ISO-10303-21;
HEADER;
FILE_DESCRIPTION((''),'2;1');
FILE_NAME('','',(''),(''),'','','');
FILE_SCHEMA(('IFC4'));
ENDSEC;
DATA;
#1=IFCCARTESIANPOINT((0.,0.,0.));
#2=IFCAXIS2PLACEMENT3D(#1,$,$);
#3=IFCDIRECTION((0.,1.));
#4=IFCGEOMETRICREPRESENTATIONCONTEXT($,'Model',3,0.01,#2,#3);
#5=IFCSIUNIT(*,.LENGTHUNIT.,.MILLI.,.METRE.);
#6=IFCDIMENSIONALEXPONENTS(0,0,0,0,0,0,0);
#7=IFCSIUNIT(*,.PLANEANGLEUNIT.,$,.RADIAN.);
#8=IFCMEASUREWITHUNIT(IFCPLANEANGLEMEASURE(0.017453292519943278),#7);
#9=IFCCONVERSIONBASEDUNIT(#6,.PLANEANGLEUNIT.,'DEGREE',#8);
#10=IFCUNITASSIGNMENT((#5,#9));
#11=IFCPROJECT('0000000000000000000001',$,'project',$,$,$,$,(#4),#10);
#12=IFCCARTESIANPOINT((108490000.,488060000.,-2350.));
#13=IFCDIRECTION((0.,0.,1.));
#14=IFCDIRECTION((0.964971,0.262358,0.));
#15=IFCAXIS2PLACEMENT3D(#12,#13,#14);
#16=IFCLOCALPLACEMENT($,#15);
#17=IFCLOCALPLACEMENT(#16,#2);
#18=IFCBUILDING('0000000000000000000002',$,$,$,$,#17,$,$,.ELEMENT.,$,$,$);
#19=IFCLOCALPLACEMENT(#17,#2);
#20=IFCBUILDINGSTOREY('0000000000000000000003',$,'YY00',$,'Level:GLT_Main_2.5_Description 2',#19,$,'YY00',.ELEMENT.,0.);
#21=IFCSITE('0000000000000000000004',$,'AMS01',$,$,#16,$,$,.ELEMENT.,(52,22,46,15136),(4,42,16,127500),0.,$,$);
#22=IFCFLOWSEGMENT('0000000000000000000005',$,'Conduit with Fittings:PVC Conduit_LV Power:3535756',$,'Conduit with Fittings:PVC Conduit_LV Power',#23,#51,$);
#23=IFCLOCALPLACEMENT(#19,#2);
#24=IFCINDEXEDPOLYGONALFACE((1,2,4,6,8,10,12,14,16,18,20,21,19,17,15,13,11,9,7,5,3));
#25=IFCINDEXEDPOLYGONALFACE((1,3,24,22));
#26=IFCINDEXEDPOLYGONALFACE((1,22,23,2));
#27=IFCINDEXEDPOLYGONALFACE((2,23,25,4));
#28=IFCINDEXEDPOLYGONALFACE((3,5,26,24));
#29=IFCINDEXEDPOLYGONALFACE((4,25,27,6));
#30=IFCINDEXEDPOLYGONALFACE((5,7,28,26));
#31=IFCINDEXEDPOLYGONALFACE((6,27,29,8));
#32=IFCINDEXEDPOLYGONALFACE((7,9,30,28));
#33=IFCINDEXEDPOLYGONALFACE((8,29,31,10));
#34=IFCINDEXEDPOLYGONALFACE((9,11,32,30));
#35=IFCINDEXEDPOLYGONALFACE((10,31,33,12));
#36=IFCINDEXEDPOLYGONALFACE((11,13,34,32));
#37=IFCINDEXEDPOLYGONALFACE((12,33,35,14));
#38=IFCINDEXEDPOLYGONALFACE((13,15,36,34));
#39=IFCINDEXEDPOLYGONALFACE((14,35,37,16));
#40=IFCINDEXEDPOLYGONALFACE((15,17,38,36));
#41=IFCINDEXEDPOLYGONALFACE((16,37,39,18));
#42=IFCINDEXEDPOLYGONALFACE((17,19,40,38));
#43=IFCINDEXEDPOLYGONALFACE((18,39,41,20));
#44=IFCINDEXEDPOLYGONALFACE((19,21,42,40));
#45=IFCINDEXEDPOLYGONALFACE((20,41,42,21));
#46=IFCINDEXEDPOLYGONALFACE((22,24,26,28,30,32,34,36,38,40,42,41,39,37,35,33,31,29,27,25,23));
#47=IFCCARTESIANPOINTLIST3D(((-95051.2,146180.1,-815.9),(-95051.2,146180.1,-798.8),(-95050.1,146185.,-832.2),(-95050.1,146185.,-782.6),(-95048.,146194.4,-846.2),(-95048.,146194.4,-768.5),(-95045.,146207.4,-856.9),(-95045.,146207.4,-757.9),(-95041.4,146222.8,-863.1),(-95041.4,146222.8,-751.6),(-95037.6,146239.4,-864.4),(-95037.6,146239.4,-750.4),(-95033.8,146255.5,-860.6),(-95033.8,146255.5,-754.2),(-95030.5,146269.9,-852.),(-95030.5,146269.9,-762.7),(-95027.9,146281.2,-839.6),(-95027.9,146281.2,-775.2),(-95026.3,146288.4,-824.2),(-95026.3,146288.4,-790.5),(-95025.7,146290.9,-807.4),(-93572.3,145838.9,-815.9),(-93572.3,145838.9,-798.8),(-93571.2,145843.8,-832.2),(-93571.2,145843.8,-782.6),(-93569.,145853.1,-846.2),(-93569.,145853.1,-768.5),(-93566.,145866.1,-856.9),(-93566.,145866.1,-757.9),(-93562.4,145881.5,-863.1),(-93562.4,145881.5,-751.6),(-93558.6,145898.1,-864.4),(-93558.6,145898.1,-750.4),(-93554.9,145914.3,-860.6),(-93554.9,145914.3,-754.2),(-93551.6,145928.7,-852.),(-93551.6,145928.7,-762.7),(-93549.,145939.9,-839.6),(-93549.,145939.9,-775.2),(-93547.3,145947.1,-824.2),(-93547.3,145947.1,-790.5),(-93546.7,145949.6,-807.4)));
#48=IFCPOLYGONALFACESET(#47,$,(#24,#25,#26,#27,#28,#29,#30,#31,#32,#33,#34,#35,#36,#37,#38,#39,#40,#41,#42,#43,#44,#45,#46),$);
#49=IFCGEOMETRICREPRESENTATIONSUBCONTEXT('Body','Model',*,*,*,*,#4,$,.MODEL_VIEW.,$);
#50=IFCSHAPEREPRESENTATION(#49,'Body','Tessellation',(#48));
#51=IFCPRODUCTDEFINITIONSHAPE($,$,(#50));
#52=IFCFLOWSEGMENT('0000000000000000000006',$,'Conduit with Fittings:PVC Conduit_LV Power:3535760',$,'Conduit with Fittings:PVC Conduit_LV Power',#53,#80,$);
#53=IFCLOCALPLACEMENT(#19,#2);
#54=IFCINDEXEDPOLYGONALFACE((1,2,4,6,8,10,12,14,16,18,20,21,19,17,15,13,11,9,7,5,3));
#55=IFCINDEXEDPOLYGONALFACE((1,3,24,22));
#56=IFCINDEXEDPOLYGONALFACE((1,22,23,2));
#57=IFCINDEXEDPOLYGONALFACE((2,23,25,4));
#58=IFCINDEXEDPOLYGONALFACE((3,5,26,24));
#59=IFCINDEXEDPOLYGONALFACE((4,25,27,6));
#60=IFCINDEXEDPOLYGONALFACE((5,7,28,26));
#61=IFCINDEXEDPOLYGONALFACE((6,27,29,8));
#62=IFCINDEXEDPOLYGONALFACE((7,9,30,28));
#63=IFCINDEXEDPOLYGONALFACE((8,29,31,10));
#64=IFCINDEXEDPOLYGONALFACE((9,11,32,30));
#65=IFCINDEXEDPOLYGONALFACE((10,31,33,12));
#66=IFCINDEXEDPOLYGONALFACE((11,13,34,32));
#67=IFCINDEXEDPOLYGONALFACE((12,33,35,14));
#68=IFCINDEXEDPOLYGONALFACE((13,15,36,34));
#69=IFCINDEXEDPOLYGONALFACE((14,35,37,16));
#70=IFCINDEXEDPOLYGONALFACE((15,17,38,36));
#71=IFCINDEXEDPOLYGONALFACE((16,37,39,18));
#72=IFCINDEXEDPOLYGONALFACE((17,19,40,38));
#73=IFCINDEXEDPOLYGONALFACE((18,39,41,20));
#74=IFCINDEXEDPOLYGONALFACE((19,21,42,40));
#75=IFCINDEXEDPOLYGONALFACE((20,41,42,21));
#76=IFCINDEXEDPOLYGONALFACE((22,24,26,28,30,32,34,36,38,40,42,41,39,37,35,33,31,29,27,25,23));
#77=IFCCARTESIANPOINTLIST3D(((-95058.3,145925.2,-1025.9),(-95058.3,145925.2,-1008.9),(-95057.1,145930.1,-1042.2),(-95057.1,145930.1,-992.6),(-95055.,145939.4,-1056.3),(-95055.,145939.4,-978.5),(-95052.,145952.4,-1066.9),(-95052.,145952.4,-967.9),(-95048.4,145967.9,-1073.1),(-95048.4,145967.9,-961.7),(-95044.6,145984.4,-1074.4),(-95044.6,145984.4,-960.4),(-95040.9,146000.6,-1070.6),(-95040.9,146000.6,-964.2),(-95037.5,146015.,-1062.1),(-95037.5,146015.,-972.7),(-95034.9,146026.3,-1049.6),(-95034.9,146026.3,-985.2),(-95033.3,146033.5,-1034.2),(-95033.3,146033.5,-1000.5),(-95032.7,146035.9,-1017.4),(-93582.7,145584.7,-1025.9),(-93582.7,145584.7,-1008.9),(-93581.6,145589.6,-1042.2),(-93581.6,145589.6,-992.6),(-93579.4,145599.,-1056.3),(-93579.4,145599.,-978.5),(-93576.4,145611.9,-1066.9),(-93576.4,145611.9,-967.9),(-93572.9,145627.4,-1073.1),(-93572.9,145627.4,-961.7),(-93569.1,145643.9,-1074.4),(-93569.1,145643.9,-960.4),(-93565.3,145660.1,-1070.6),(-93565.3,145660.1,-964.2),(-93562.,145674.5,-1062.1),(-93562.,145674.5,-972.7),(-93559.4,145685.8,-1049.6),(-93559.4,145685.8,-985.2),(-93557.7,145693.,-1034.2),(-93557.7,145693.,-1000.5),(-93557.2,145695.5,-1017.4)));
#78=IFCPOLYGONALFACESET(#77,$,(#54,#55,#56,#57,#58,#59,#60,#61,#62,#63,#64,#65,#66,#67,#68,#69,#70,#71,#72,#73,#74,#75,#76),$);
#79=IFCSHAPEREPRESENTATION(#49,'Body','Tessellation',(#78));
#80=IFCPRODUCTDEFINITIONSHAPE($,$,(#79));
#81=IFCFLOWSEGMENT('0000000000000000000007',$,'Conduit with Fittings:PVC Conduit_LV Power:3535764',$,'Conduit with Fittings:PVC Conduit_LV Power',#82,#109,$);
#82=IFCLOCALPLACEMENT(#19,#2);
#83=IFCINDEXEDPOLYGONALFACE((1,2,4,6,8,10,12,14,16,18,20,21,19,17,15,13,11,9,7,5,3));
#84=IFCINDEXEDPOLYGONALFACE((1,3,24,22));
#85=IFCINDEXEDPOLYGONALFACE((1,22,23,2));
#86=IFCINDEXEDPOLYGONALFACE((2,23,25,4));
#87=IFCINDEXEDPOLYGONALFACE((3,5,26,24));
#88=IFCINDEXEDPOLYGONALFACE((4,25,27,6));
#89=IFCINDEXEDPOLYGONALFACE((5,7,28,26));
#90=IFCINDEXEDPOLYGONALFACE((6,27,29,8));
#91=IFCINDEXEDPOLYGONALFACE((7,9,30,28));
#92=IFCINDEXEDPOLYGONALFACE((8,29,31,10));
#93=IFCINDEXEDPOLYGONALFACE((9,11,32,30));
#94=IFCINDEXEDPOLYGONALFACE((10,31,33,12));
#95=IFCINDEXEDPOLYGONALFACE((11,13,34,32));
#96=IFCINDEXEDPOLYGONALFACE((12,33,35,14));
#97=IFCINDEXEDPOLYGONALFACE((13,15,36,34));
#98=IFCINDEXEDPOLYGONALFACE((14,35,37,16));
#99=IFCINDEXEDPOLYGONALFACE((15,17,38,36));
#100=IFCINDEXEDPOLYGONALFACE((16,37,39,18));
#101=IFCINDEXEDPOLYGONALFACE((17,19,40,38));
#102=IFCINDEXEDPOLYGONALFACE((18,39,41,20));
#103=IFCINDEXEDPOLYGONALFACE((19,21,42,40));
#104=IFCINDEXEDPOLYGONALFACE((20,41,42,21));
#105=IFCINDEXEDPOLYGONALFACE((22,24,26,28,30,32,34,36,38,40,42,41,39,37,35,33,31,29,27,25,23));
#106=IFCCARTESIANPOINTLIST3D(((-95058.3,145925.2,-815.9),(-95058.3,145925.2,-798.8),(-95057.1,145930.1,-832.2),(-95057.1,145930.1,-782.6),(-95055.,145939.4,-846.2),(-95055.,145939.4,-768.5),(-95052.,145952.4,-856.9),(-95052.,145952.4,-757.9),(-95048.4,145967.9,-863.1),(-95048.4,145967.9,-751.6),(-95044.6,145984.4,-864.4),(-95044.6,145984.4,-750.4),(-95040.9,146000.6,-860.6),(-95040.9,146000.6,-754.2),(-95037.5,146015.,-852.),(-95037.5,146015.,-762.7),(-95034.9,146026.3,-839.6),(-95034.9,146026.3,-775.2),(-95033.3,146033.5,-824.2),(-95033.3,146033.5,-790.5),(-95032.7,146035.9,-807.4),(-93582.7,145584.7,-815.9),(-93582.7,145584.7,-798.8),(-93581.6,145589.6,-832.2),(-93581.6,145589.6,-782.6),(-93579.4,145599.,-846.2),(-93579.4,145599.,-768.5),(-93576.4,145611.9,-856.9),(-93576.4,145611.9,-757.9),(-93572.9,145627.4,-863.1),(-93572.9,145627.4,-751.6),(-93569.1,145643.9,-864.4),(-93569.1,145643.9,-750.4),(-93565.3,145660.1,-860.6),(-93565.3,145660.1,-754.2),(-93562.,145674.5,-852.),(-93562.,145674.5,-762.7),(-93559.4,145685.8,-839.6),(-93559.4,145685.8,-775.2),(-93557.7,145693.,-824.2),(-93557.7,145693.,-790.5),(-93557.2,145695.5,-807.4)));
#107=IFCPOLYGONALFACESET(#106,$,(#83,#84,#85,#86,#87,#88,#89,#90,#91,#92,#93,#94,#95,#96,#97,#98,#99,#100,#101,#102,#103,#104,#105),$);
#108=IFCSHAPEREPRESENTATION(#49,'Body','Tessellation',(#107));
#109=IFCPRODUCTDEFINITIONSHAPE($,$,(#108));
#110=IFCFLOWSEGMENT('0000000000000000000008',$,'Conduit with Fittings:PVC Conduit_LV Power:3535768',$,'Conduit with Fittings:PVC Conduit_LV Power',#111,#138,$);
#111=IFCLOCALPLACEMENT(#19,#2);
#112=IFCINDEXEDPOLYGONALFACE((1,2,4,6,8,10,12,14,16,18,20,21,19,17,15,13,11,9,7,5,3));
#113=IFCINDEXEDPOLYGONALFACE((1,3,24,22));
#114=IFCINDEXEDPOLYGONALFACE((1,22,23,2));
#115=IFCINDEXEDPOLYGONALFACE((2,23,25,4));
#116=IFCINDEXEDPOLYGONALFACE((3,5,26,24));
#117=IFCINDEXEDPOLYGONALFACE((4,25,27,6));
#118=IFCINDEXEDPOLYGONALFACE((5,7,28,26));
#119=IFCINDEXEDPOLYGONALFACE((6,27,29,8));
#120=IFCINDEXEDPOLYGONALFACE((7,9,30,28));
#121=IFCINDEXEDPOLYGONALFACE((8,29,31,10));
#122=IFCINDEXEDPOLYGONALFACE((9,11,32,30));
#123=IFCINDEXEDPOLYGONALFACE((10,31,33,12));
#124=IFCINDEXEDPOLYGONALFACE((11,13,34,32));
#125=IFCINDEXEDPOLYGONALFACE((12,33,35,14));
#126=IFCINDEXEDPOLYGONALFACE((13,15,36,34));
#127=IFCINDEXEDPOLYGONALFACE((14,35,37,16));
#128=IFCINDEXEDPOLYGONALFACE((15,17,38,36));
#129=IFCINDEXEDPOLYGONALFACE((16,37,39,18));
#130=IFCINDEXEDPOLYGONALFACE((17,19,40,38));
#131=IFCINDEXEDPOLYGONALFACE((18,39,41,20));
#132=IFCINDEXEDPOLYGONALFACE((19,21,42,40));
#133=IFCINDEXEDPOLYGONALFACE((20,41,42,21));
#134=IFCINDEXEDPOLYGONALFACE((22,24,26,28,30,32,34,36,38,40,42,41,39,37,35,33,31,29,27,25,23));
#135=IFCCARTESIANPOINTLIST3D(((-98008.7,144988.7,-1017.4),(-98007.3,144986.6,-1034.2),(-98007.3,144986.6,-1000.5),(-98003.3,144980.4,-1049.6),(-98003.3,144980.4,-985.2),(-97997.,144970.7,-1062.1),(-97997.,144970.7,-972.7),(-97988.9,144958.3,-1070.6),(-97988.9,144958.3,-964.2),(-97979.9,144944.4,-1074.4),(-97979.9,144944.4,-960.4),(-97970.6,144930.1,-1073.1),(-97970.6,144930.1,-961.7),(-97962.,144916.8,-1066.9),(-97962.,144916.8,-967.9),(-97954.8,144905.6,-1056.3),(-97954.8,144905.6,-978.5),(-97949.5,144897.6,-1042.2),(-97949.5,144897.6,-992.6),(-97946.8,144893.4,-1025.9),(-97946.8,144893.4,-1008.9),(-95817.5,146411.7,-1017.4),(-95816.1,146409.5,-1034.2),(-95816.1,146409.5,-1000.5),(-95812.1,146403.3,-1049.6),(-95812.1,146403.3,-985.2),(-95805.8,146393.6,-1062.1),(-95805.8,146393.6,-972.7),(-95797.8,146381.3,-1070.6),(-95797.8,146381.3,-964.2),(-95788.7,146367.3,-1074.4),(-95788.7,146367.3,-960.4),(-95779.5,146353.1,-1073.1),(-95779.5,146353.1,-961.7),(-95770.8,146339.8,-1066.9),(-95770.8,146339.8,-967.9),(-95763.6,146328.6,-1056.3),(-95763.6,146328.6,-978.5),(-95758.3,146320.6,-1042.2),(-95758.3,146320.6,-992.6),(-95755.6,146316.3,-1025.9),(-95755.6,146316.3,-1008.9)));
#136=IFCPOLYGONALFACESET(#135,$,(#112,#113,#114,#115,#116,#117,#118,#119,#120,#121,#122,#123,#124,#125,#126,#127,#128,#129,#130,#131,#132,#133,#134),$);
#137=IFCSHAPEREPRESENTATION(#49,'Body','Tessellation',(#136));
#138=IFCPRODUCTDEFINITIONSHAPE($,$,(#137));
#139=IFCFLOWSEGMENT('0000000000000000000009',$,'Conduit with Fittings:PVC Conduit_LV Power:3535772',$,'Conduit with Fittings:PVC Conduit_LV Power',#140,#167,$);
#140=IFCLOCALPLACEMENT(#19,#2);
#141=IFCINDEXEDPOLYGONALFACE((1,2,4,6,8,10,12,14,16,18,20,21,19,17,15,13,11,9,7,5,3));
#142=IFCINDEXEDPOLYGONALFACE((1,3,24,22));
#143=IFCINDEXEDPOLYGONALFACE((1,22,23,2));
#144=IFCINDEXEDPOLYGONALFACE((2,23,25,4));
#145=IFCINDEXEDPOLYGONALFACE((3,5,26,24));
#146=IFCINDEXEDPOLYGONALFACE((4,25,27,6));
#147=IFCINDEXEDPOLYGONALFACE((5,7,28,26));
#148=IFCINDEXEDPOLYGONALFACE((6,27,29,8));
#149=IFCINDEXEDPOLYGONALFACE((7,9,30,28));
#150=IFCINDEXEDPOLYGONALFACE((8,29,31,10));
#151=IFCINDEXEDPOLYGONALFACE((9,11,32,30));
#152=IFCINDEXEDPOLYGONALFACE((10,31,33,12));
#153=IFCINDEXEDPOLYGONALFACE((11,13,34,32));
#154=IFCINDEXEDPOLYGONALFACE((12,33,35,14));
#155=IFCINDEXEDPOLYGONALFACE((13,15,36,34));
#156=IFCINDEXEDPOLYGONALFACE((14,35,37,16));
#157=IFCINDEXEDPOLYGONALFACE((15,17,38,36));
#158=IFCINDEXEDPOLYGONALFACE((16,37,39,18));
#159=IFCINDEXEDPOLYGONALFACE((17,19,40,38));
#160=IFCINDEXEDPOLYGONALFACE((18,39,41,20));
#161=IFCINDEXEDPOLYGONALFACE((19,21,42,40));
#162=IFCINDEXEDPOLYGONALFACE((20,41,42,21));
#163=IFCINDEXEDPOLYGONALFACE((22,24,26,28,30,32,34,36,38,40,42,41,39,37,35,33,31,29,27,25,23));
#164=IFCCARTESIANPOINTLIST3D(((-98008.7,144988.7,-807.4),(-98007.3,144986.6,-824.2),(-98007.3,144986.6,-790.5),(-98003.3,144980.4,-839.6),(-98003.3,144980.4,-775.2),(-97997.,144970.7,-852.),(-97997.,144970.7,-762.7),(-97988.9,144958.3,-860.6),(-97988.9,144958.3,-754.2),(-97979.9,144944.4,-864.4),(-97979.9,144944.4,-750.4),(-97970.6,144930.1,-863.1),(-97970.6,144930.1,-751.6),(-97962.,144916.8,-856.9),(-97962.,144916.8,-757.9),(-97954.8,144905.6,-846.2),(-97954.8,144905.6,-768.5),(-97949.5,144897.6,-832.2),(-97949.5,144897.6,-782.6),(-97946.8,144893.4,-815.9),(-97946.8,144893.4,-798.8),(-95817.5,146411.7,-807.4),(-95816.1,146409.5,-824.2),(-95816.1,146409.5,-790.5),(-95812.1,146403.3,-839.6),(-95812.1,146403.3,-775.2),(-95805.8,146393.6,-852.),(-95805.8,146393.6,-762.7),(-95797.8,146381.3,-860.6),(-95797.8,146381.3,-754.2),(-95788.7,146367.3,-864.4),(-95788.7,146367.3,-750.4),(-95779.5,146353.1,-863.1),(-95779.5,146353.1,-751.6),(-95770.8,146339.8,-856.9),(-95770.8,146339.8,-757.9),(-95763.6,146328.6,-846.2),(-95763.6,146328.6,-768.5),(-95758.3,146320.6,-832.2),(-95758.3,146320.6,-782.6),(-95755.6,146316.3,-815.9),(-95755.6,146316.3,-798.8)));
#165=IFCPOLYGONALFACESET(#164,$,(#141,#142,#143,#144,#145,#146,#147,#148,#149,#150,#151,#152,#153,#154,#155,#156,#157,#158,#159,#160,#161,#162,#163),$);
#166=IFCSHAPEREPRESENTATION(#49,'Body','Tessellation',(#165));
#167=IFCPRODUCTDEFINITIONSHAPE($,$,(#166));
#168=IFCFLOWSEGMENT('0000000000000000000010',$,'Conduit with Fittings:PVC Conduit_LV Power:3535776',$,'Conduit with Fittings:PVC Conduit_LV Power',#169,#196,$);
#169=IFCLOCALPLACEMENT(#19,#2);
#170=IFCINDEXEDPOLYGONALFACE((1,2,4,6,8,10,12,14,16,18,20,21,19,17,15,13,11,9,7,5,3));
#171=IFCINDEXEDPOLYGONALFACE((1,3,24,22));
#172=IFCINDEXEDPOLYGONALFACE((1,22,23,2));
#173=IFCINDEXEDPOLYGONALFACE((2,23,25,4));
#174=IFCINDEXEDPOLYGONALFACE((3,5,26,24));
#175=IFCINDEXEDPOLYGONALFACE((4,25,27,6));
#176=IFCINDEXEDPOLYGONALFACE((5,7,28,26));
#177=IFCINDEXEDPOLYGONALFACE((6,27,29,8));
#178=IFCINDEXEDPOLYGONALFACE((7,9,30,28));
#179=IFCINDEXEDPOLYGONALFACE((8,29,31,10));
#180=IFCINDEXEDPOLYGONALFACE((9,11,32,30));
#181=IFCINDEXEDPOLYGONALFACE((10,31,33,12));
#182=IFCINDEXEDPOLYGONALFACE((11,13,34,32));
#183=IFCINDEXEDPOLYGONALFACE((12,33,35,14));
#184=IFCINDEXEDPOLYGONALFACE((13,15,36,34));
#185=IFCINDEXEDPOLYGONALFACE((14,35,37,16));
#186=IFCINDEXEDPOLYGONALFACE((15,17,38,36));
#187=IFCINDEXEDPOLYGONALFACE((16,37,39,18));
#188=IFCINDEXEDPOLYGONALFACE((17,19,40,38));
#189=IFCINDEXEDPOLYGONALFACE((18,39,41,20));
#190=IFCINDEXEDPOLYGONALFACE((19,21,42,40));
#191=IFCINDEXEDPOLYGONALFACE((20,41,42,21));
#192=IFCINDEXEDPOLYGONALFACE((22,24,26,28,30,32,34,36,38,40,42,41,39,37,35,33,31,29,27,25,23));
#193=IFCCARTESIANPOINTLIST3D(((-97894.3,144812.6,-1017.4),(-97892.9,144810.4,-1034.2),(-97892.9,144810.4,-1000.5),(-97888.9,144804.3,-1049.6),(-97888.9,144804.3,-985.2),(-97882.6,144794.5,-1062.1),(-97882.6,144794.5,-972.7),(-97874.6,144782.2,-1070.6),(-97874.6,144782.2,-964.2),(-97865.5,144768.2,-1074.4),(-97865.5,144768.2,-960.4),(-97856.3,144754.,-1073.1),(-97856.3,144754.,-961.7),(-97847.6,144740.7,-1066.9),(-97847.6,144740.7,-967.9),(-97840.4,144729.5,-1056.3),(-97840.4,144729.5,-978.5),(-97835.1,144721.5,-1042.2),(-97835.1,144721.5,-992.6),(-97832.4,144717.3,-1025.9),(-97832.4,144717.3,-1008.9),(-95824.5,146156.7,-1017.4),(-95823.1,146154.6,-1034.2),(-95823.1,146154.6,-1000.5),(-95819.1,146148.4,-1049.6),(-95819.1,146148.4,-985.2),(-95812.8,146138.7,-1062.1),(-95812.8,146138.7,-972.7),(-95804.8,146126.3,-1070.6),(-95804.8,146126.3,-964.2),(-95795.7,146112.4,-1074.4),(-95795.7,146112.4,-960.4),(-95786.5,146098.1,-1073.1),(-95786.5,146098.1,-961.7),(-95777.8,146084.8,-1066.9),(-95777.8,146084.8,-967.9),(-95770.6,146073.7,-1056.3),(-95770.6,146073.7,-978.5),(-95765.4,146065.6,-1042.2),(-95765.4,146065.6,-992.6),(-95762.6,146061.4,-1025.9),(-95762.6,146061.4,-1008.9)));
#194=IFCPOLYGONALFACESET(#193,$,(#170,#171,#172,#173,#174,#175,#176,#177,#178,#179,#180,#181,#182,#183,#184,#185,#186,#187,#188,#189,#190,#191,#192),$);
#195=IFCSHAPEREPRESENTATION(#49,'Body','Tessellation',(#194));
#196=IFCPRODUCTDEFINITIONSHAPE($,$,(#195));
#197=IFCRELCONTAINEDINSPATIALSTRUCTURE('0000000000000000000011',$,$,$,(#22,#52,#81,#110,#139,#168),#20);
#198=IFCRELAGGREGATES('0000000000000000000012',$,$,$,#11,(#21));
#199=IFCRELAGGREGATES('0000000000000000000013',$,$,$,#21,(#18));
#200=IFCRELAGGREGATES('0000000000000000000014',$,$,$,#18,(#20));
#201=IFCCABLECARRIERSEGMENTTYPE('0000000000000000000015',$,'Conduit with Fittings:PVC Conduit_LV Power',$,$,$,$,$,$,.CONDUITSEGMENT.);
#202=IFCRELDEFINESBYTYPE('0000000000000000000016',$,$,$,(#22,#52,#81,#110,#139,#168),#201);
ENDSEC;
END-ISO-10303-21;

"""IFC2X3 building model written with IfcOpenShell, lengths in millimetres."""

from ifc_helpers import new_model, entity, si_unit, converted_unit, direction, frame, frame_2d, origin, origin_2d_with_axis, place, context, subcontext, project, spatial, circle, extrude, type_object, element, save


model = new_model("IFC2X3")

# Units and contexts
model_context = context("Model", 3, precision=0.01, world=origin(), true_north=direction((0.0, 1.0)))
body_context = subcontext(model_context, "Body", "Model", "MODEL_VIEW")
ifc_project = project(units=[si_unit("LENGTHUNIT", "METRE", prefix="MILLI"), converted_unit("PLANEANGLEUNIT", "DEGREE", entity("IfcPlaneAngleMeasure", 0.017453292519943278), si_unit("PLANEANGLEUNIT", "RADIAN"), dimensions=[0, 0, 0, 0, 0, 0, 0])], contexts=[model_context])

# Site, building, storey
site_placement = place(None, frame((108490000.0, 488060000.0, -2350.0), z_axis=(0.0, 0.0, 1.0), x_axis=(0.964971, 0.262358, 0.0)))
site = spatial("IfcSite", under=ifc_project, at=site_placement, Name="AMS01", CompositionType="ELEMENT", RefLatitude=(52, 22, 46, 15136), RefLongitude=(4, 42, 16, 127500), RefElevation=0.0)
building_placement = place(site_placement, origin())
building = spatial("IfcBuilding", under=site, at=building_placement, CompositionType="ELEMENT")
storey_placement = place(building_placement, origin())
storey = spatial("IfcBuildingStorey", under=building, at=storey_placement, Name="YY00", ObjectType="Level:GLT_Main_2.5_Description 2", LongName="YY00", CompositionType="ELEMENT", Elevation=0.0)

# Flow segments
cable_carrier_segment_type = type_object("IfcCableCarrierSegmentType", Name="Conduit with Fittings:PVC Conduit_LV Power", PredefinedType="CONDUITSEGMENT")
flow_segment_1_placement = place(storey_placement, origin())
element("IfcFlowSegment", 1, at=flow_segment_1_placement, inside=storey, type_object=cable_carrier_segment_type, Name="Conduit with Fittings:PVC Conduit_LV Power:3535756", ObjectType="Conduit with Fittings:PVC Conduit_LV Power", context=body_context, shape_type="SweptSolid", body=[
    extrude(circle(Radius=57.2, at=origin_2d_with_axis()), frame((-93559.6, 145893.9, -807.4), z_axis=(-0.974396, 0.224839, 0.0), x_axis=(0.224839, 0.974396, 0.0)), (0.0, 0.0, 1.0), 1517.8),
])
flow_segment_2_placement = place(storey_placement, origin())
element("IfcFlowSegment", 2, at=flow_segment_2_placement, inside=storey, type_object=cable_carrier_segment_type, Name="Conduit with Fittings:PVC Conduit_LV Power:3535760", ObjectType="Conduit with Fittings:PVC Conduit_LV Power", context=body_context, shape_type="SweptSolid", body=[
    extrude(circle(Radius=57.2, at=frame_2d((0.0, 0.0), x_axis=(1.0, 0.0))), frame((-93570.0, 145639.8, -1017.4), z_axis=(-0.974396, 0.224839, 0.0), x_axis=(0.224839, 0.974396, 0.0)), (0.0, 0.0, 1.0), 1514.3),
])
flow_segment_3_placement = place(storey_placement, origin())
element("IfcFlowSegment", 3, at=flow_segment_3_placement, inside=storey, type_object=cable_carrier_segment_type, Name="Conduit with Fittings:PVC Conduit_LV Power:3535764", ObjectType="Conduit with Fittings:PVC Conduit_LV Power", context=body_context, shape_type="SweptSolid", body=[
    extrude(circle(Radius=57.2, at=frame_2d((0.0, 0.0), x_axis=(1.0, 0.0))), frame((-93570.0, 145639.8, -807.4), z_axis=(-0.974396, 0.224839, 0.0), x_axis=(0.224839, 0.974396, 0.0)), (0.0, 0.0, 1.0), 1514.3),
])
flow_segment_4_placement = place(storey_placement, origin())
element("IfcFlowSegment", 4, at=flow_segment_4_placement, inside=storey, type_object=cable_carrier_segment_type, Name="Conduit with Fittings:PVC Conduit_LV Power:3535768", ObjectType="Conduit with Fittings:PVC Conduit_LV Power", context=body_context, shape_type="SweptSolid", body=[
    extrude(circle(Radius=57.2, at=origin_2d_with_axis()), frame((-97977.6, 144940.8, -1017.4), z_axis=(0.838671, 0.544639, 0.0), x_axis=(-0.544639, 0.838671, 0.0)), (0.0, 0.0, 1.0), 2612.7),
])
flow_segment_5_placement = place(storey_placement, origin())
element("IfcFlowSegment", 5, at=flow_segment_5_placement, inside=storey, type_object=cable_carrier_segment_type, Name="Conduit with Fittings:PVC Conduit_LV Power:3535772", ObjectType="Conduit with Fittings:PVC Conduit_LV Power", context=body_context, shape_type="SweptSolid", body=[
    extrude(circle(Radius=57.2, at=origin_2d_with_axis()), frame((-97977.6, 144940.8, -807.4), z_axis=(0.838671, 0.544639, 0.0), x_axis=(-0.544639, 0.838671, 0.0)), (0.0, 0.0, 1.0), 2612.7),
])
flow_segment_6_placement = place(storey_placement, origin())
element("IfcFlowSegment", 6, at=flow_segment_6_placement, inside=storey, type_object=cable_carrier_segment_type, Name="Conduit with Fittings:PVC Conduit_LV Power:3535776", ObjectType="Conduit with Fittings:PVC Conduit_LV Power", context=body_context, shape_type="SweptSolid", body=[
    extrude(circle(Radius=57.2, at=origin_2d_with_axis()), frame((-97863.2, 144764.6, -1017.4), z_axis=(0.838671, 0.544639, 0.0), x_axis=(-0.544639, 0.838671, 0.0)), (0.0, 0.0, 1.0), 2468.0),
])

save(model, "model.ifc")
